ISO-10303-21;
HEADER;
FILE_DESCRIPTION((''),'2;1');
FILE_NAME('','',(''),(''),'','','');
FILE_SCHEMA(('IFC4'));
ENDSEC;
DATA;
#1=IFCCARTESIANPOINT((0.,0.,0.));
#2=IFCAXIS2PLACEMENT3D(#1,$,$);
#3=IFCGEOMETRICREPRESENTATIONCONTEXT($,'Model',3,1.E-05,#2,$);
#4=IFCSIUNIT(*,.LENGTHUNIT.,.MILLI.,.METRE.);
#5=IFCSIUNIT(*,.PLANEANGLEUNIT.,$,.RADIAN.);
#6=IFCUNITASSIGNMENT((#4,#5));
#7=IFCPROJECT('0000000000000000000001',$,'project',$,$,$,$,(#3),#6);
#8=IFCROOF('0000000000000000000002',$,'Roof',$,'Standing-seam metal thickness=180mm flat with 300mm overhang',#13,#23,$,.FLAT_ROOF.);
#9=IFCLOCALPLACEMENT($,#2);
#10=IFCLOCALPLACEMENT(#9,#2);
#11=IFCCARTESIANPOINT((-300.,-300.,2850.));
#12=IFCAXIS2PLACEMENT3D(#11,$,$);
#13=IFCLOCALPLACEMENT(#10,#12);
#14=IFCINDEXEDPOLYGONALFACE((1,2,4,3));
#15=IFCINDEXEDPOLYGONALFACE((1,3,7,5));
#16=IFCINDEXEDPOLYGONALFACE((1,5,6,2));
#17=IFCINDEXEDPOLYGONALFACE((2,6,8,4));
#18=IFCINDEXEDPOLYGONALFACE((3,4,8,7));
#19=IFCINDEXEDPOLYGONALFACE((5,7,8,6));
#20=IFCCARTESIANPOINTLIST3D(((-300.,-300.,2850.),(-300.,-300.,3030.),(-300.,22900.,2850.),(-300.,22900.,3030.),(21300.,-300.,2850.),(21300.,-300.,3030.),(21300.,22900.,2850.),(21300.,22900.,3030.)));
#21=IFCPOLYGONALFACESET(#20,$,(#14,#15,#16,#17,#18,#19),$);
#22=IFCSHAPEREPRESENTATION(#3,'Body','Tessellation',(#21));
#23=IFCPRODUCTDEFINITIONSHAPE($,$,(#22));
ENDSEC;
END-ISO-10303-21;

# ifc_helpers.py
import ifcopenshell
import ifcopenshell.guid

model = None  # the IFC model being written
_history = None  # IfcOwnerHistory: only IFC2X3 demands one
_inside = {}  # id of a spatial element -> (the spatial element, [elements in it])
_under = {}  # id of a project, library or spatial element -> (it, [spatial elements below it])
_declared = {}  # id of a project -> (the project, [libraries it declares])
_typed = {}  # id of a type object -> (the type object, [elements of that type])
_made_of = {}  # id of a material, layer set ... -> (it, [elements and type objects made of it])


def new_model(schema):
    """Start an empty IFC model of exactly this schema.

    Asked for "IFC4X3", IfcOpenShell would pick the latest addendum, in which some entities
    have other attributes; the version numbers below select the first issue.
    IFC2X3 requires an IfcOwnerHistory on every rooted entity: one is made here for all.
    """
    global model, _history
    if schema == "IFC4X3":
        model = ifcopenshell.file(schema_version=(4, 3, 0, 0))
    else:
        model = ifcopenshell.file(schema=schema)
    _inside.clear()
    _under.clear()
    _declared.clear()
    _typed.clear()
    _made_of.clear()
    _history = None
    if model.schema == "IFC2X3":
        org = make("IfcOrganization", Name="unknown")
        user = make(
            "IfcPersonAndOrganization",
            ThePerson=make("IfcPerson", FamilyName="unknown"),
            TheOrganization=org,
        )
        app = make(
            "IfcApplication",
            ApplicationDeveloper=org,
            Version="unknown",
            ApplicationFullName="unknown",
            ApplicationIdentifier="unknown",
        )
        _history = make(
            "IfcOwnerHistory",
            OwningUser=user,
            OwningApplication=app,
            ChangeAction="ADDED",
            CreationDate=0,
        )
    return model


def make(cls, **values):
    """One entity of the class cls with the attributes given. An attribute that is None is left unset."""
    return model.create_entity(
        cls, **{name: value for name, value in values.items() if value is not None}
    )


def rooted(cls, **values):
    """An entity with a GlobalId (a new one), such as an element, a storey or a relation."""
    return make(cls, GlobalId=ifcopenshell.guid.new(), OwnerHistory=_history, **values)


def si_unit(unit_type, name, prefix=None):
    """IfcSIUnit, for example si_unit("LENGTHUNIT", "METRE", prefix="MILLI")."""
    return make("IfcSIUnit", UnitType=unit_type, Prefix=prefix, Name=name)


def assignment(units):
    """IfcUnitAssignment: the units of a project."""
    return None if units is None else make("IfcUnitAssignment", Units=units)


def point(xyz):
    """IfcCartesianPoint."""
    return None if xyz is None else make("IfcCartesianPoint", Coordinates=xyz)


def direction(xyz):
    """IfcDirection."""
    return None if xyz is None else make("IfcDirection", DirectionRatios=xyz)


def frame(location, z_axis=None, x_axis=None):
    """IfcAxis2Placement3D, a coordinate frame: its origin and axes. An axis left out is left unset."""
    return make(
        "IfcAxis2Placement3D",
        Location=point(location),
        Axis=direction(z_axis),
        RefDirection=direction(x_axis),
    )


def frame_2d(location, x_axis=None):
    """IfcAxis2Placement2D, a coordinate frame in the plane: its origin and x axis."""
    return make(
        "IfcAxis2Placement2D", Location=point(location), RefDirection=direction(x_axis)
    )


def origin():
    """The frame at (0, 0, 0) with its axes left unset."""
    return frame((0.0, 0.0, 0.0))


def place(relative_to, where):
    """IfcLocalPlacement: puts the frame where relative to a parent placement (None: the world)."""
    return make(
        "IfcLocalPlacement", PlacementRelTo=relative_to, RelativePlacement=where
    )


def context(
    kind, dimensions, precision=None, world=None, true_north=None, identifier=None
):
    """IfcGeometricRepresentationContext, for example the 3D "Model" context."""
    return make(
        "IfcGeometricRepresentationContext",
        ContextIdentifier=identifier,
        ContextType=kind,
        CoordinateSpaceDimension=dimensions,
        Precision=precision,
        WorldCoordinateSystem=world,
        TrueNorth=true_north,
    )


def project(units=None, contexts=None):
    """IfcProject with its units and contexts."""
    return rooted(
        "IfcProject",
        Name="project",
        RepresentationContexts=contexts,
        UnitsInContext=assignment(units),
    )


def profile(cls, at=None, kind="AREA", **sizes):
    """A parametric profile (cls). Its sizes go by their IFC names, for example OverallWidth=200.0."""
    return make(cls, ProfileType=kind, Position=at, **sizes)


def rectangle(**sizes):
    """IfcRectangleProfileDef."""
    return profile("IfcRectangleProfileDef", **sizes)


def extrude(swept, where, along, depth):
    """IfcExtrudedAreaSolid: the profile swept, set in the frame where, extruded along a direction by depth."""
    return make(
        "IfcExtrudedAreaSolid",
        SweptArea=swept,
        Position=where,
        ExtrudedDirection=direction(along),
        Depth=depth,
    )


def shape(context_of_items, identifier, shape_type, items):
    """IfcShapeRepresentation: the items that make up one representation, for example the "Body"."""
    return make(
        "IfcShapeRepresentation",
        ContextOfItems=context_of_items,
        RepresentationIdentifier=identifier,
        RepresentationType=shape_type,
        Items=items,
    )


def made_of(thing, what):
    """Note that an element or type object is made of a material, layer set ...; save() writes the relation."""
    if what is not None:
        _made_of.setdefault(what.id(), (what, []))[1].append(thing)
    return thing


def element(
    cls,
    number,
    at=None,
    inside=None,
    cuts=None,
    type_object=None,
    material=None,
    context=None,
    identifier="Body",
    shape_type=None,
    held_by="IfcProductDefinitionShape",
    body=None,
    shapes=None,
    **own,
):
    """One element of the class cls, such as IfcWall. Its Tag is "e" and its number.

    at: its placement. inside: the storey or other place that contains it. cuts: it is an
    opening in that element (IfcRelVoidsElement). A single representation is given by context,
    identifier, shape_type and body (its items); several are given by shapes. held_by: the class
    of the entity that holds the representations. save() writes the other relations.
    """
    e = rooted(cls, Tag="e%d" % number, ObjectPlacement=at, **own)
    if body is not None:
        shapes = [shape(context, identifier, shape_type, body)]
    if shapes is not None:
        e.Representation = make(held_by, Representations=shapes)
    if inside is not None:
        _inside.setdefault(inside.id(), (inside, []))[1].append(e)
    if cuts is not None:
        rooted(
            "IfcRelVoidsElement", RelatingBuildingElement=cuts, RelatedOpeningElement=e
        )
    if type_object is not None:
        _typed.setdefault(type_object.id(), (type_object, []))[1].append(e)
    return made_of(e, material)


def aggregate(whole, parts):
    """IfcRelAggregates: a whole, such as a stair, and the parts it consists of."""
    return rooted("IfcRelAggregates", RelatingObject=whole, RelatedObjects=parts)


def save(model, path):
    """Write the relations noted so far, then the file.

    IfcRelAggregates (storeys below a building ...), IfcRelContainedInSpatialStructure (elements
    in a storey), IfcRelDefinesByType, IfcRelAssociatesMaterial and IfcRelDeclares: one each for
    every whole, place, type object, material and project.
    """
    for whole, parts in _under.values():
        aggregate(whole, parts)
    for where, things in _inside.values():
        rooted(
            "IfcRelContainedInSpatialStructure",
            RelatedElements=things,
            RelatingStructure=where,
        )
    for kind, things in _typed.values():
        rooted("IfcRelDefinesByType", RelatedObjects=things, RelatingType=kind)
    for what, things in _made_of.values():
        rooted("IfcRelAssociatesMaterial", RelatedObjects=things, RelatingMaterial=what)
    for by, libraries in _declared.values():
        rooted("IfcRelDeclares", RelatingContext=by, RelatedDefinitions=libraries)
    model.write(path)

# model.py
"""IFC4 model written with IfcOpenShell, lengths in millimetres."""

from ifc_helpers import new_model, si_unit, frame, frame_2d, origin, place, context, project, rectangle, extrude, element, save


model = new_model("IFC4")

# Units and contexts
model_context = context("Model", 3, precision=1e-05, world=origin())
ifc_project = project(units=[si_unit("LENGTHUNIT", "METRE", prefix="MILLI"), si_unit("PLANEANGLEUNIT", "RADIAN")], contexts=[model_context])

# Roof
placement_1 = place(None, origin())
placement_2 = place(placement_1, origin())
roof_placement = place(placement_2, frame((-300.0, -300.0, 2850.0)))
element("IfcRoof", 1, at=roof_placement, Name="Roof", ObjectType="Standing-seam metal thickness=180mm flat with 300mm overhang", PredefinedType="FLAT_ROOF", context=model_context, shape_type="SweptSolid", body=[
    extrude(rectangle(XDim=21600.0, YDim=23200.0, at=frame_2d((10800.0, 11600.0))), frame((-300.0, -300.0, 2850.0)), (0.0, 0.0, 1.0), 180.0),
])

save(model, "model.ifc")
